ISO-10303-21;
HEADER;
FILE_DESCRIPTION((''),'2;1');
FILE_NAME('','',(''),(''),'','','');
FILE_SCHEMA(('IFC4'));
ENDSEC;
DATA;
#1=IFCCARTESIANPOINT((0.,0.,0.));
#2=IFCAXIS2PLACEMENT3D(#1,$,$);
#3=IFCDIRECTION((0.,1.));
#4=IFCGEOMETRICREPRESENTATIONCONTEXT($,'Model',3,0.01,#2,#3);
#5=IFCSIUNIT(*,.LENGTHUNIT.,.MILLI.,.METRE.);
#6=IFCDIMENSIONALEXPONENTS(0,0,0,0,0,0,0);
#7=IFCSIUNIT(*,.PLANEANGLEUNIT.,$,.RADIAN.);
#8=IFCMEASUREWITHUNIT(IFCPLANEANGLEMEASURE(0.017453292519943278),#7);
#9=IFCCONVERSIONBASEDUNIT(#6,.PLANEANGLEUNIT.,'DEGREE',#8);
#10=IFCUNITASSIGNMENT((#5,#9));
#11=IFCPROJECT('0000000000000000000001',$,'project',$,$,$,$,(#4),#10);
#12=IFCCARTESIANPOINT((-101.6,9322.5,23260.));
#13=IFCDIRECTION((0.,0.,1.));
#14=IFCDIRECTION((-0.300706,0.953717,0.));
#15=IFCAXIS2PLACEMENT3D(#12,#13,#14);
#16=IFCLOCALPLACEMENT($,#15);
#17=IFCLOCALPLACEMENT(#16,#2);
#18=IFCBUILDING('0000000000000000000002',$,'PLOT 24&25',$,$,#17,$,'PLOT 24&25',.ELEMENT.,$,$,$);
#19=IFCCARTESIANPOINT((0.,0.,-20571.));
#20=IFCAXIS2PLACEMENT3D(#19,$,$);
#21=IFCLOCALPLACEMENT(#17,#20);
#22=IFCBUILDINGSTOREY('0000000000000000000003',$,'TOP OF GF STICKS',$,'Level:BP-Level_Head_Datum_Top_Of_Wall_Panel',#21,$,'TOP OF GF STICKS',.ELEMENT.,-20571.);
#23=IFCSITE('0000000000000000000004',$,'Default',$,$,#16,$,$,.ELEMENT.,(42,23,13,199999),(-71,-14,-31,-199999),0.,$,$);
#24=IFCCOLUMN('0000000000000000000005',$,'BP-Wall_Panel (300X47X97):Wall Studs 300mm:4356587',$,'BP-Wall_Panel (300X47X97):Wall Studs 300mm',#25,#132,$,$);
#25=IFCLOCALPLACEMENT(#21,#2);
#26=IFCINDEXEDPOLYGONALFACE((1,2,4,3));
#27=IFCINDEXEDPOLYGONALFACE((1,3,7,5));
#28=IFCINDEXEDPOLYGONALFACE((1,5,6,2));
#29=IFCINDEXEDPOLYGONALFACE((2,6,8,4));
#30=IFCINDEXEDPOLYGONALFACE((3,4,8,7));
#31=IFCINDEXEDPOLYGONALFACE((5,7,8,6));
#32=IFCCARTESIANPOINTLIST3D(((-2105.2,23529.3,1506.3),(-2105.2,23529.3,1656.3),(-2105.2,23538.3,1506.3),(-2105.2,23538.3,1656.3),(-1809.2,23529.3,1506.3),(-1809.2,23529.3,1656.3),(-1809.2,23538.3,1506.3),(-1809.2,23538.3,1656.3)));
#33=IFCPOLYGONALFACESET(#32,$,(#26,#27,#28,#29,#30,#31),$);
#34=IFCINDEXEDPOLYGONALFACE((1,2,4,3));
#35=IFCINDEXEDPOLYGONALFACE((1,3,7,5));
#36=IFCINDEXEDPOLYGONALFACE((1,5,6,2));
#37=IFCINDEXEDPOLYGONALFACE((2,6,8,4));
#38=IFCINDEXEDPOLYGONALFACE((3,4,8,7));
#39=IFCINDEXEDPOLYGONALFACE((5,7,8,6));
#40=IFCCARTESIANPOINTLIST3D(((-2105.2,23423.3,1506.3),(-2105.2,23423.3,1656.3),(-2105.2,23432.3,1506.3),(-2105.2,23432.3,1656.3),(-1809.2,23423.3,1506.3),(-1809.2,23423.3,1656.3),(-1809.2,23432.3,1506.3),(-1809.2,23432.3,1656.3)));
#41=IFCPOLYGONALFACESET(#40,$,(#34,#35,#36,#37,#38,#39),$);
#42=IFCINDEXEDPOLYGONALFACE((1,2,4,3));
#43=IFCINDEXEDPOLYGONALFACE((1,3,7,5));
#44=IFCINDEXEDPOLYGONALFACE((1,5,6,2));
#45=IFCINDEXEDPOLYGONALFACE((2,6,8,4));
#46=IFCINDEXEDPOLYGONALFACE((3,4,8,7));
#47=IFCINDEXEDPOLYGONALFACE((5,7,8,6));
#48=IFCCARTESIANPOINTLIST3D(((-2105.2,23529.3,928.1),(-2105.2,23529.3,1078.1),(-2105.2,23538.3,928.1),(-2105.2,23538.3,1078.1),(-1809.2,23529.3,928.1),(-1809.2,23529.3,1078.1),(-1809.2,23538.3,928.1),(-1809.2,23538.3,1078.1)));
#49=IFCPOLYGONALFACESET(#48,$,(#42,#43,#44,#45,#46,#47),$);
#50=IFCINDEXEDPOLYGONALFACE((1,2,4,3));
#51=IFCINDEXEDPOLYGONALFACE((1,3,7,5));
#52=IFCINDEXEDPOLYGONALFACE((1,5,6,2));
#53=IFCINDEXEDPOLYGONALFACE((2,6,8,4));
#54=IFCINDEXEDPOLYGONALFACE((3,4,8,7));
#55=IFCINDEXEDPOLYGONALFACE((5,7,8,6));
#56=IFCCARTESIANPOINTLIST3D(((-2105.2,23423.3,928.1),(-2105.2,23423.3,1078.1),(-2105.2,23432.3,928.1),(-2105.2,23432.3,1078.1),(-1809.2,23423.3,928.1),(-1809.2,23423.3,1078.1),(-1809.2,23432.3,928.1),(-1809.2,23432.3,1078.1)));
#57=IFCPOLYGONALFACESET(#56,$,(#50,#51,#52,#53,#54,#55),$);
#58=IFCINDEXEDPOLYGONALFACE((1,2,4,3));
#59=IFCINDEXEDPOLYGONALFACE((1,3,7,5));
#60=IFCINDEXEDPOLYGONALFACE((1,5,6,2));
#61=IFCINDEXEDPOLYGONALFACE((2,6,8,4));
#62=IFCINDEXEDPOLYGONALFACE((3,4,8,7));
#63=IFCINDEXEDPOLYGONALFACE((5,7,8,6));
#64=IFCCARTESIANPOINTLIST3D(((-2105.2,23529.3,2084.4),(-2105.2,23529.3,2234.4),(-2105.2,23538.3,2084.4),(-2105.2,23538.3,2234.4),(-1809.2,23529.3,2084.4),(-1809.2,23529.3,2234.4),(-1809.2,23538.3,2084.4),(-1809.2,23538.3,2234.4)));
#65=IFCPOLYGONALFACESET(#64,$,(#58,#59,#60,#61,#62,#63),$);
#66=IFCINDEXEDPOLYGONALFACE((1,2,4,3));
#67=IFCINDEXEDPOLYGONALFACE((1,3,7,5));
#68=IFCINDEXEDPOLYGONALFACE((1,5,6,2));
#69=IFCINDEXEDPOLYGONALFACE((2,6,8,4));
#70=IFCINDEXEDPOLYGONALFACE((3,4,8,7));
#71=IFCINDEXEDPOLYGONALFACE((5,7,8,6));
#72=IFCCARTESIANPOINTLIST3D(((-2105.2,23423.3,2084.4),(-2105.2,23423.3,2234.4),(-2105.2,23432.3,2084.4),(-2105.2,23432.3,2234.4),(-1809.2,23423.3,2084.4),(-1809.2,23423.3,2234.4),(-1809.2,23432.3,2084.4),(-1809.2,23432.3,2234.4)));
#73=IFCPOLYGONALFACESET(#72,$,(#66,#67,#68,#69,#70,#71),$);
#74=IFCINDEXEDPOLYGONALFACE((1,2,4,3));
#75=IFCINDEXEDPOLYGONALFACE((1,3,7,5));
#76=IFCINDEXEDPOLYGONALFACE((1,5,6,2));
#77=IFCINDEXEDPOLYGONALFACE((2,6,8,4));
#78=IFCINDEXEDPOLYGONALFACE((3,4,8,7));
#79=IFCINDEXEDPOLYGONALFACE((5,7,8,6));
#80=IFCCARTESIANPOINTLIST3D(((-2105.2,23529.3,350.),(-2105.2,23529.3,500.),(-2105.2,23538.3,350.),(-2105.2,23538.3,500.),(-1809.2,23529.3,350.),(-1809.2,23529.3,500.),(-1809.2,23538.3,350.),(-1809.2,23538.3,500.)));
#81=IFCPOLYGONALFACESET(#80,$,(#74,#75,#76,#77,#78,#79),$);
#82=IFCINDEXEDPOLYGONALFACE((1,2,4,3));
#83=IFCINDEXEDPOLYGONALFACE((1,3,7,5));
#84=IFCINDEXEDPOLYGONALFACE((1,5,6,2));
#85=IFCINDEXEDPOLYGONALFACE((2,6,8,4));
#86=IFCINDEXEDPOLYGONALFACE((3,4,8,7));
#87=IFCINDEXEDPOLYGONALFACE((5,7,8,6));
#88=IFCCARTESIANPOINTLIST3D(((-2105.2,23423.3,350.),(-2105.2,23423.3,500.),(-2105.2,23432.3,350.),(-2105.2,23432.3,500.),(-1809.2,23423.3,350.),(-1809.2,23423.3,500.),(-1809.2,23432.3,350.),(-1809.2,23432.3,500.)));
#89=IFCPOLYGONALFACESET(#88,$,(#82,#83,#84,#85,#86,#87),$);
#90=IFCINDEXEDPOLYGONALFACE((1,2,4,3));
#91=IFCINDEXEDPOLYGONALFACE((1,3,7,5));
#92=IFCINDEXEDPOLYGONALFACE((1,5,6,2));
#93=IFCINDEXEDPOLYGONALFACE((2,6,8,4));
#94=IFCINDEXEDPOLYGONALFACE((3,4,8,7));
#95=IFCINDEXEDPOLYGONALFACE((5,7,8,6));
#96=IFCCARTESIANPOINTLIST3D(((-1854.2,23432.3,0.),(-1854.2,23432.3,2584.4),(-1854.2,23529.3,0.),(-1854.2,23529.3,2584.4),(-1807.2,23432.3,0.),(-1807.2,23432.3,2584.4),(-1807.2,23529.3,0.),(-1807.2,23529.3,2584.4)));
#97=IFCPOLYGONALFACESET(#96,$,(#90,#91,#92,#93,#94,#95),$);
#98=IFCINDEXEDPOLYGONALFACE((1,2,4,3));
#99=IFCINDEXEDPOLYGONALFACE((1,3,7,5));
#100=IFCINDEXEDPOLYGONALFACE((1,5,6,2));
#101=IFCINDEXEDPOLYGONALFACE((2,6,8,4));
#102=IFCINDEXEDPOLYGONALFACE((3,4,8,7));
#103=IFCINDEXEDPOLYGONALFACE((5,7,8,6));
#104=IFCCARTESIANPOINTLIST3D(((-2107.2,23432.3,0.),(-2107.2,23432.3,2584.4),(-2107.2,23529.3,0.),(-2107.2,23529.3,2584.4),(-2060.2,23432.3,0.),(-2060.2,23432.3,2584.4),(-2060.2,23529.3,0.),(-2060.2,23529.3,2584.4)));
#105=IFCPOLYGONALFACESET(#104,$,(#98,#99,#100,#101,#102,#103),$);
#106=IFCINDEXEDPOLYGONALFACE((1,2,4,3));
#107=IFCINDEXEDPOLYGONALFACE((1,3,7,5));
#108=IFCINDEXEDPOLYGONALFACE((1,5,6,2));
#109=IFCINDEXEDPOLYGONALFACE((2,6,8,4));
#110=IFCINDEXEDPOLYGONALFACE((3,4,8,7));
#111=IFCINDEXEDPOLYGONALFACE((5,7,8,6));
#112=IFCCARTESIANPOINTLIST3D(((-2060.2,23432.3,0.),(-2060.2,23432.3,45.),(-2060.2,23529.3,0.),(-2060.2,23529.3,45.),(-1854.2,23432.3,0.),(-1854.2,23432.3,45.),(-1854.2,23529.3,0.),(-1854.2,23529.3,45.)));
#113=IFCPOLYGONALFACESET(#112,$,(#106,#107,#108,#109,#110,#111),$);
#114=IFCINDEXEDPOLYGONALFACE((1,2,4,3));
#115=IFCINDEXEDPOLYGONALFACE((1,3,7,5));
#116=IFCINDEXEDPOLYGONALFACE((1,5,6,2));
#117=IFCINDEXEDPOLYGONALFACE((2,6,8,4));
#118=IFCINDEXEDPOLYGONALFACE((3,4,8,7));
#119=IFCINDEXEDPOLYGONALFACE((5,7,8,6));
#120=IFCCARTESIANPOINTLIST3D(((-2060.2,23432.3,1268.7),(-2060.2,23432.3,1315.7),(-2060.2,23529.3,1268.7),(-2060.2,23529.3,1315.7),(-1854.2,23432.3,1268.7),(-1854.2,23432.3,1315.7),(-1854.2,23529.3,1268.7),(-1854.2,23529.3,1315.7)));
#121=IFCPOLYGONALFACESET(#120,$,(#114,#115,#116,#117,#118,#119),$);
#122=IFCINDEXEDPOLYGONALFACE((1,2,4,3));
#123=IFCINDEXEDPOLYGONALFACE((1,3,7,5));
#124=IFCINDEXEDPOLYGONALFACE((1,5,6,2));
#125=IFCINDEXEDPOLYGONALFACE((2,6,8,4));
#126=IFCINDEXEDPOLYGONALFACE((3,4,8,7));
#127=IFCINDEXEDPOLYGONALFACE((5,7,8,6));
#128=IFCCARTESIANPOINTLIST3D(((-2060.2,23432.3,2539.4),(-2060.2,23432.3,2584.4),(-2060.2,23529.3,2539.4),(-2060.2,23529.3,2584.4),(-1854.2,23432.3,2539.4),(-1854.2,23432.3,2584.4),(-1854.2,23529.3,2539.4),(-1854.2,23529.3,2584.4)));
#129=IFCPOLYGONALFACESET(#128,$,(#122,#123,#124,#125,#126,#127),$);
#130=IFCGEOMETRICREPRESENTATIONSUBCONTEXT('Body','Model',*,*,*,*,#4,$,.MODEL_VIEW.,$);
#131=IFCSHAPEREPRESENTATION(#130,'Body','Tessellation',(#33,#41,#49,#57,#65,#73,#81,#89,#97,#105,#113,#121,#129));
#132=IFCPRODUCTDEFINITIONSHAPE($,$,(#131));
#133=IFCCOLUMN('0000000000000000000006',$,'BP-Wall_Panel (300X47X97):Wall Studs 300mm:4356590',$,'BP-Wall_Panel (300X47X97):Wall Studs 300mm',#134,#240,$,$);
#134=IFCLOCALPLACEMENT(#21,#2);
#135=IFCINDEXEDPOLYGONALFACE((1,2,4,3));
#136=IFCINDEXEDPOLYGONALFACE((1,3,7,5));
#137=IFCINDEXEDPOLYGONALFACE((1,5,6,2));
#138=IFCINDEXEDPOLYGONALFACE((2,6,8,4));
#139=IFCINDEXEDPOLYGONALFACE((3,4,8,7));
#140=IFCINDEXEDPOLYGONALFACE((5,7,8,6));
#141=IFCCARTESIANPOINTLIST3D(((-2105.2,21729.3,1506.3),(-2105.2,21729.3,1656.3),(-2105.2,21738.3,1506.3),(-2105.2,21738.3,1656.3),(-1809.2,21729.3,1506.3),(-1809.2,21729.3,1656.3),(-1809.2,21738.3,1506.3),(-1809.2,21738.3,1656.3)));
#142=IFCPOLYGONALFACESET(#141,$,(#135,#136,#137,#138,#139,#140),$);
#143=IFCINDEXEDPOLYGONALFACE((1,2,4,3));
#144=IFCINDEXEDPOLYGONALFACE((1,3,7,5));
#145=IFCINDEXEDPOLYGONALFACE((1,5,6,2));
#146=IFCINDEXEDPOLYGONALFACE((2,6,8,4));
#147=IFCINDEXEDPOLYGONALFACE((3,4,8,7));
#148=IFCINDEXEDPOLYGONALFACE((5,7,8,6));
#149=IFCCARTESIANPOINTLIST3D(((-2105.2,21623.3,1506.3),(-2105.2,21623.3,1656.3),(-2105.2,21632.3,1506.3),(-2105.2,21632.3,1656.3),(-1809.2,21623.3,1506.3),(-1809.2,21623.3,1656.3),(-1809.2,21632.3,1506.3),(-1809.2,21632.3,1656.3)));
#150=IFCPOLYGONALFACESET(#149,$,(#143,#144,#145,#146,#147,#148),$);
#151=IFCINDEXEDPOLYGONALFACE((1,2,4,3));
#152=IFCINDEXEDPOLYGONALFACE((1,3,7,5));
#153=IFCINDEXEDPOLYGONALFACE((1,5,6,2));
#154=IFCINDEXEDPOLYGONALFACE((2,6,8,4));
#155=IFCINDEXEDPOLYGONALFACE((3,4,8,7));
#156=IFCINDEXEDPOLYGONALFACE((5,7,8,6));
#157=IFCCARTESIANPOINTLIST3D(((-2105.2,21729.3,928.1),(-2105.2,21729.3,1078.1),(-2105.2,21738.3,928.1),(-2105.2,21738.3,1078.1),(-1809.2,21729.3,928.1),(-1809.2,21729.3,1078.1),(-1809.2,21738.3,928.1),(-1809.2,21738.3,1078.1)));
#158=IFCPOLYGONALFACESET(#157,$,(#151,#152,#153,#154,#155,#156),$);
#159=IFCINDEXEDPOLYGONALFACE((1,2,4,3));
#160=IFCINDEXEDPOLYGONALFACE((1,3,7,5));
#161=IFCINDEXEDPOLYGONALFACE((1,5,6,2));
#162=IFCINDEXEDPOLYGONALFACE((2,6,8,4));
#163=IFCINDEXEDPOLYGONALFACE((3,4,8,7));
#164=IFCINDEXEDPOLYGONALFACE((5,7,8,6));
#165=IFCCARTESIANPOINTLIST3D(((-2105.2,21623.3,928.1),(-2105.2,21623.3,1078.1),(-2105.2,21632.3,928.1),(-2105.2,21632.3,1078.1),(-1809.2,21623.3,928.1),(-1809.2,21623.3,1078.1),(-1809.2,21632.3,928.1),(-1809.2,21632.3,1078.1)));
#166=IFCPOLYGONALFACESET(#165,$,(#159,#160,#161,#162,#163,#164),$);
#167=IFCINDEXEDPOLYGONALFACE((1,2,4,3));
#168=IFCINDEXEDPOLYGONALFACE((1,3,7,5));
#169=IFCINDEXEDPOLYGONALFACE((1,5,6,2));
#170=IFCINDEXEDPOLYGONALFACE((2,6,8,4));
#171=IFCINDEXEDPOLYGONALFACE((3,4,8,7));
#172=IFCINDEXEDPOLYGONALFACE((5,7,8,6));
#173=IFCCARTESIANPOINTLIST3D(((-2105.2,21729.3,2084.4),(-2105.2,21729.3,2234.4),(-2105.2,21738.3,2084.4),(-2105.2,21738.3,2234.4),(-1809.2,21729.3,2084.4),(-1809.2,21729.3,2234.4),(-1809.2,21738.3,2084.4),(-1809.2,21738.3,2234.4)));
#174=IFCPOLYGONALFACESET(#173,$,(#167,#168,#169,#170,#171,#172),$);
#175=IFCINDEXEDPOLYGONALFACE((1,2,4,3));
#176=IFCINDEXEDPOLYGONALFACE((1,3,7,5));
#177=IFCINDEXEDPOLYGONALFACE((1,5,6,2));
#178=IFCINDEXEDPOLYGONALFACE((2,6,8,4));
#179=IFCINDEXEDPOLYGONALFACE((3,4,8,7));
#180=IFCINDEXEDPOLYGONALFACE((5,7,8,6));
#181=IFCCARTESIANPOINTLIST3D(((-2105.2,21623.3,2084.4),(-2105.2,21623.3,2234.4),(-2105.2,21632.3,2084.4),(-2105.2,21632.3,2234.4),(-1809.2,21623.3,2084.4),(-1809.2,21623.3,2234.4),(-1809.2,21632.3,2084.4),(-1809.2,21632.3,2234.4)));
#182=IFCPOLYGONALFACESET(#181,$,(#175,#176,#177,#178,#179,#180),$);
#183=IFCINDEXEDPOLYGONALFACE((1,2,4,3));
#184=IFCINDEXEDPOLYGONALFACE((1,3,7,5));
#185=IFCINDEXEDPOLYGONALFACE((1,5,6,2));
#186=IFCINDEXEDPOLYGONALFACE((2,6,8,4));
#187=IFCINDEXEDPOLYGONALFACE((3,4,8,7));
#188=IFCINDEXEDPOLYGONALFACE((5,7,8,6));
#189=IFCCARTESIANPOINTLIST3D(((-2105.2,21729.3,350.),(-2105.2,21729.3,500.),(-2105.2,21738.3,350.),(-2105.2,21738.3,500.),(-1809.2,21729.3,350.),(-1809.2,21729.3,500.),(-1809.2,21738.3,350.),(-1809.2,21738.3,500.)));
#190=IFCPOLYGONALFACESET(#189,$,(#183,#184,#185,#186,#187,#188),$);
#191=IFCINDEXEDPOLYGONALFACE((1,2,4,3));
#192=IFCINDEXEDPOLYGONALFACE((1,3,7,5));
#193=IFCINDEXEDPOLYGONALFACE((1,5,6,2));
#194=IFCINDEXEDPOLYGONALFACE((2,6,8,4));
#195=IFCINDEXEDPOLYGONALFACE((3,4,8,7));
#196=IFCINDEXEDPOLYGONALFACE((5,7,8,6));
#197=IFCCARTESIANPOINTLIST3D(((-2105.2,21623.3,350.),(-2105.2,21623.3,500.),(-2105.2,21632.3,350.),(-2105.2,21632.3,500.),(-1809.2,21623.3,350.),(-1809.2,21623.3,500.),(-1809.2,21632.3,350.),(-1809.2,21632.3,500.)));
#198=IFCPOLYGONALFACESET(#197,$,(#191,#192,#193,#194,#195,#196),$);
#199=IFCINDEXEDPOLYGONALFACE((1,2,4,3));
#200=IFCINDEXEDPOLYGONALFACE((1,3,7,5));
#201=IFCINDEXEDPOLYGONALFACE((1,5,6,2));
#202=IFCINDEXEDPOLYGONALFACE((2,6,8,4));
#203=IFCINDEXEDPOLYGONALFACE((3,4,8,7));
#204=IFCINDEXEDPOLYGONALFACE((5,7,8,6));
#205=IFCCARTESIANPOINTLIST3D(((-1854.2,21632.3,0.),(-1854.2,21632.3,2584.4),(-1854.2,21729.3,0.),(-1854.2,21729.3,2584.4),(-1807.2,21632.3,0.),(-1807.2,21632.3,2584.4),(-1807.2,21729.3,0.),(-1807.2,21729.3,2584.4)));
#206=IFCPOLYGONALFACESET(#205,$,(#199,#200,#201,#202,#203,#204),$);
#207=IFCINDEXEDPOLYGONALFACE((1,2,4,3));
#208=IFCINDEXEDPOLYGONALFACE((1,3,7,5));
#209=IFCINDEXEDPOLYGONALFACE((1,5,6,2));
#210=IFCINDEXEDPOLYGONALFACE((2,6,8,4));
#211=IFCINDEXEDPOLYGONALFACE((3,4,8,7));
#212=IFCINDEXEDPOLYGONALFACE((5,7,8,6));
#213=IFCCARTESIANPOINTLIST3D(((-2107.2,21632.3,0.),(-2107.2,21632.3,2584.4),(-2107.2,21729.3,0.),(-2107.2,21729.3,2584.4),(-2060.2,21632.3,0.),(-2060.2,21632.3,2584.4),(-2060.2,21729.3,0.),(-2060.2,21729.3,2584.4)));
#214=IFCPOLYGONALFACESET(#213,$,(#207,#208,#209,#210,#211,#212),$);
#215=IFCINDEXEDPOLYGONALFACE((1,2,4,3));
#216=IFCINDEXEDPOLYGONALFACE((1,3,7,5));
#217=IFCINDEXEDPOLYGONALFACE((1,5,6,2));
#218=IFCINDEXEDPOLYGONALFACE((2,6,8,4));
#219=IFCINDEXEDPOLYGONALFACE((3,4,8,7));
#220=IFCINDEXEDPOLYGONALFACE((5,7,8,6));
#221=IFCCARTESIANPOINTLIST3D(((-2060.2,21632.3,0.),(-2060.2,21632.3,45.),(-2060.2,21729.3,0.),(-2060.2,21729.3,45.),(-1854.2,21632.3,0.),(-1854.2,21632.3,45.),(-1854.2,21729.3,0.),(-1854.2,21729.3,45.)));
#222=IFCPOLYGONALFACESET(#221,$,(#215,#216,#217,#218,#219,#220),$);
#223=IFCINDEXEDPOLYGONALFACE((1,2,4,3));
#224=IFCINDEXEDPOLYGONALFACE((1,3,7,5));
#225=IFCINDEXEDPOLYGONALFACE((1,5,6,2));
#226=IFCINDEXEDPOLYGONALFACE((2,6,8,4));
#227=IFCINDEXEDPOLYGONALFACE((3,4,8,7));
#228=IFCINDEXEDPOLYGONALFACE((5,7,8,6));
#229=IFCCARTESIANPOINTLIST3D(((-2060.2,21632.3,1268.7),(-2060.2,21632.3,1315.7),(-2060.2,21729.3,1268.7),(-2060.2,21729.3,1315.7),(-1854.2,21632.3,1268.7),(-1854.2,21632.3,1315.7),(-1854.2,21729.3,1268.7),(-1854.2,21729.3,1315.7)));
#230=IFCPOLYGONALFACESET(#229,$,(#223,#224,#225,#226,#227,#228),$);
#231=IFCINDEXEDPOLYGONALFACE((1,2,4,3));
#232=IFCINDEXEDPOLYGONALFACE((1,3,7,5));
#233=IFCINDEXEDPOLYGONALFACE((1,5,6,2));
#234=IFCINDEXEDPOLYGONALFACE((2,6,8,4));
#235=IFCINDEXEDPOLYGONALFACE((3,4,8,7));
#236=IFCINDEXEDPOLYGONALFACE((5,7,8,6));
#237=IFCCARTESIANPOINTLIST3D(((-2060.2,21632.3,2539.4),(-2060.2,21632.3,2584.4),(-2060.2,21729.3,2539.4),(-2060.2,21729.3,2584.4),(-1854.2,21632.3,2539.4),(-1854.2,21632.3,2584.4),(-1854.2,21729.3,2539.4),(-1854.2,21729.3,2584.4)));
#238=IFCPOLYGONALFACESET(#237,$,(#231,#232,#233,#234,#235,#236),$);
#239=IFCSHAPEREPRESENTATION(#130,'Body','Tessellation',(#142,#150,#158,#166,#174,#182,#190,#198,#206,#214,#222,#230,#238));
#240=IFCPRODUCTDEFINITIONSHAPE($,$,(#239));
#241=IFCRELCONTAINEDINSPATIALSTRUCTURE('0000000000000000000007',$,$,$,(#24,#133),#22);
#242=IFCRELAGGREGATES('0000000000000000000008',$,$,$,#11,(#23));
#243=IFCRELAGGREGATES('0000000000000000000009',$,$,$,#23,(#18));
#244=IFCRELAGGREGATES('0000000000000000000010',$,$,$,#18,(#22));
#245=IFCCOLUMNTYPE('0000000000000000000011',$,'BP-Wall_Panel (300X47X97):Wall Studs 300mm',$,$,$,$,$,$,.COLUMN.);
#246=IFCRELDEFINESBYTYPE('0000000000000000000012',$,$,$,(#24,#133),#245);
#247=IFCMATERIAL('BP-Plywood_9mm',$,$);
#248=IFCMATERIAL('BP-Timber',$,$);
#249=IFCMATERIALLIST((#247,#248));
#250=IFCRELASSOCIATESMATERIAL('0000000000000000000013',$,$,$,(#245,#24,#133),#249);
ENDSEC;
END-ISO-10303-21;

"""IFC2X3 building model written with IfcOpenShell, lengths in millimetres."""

from ifc_helpers import new_model, entity, si_unit, converted_unit, direction, frame, frame_2d, origin, origin_2d_with_axis, place, context, subcontext, project, spatial, rectangle, extrude, source, transform, mapped, material, material_list, type_object, type_shapes, element, save


model = new_model("IFC2X3")

# Units and contexts
model_context = context("Model", 3, precision=0.01, world=origin(), true_north=direction((0.0, 1.0)))
body_context = subcontext(model_context, "Body", "Model", "MODEL_VIEW")
ifc_project = project(units=[si_unit("LENGTHUNIT", "METRE", prefix="MILLI"), converted_unit("PLANEANGLEUNIT", "DEGREE", entity("IfcPlaneAngleMeasure", 0.017453292519943278), si_unit("PLANEANGLEUNIT", "RADIAN"), dimensions=[0, 0, 0, 0, 0, 0, 0])], contexts=[model_context])

# Site, building, storey
site_placement = place(None, frame((-101.6, 9322.5, 23260.0), z_axis=(0.0, 0.0, 1.0), x_axis=(-0.300706, 0.953717, 0.0)))
site = spatial("IfcSite", under=ifc_project, at=site_placement, Name="Default", CompositionType="ELEMENT", RefLatitude=(42, 23, 13, 199999), RefLongitude=(-71, -14, -31, -199999), RefElevation=0.0)
building_placement = place(site_placement, origin())
building = spatial("IfcBuilding", under=site, at=building_placement, Name="PLOT 24&25", LongName="PLOT 24&25", CompositionType="ELEMENT")
storey_placement = place(building_placement, frame((0.0, 0.0, -20571.0)))
storey = spatial("IfcBuildingStorey", under=building, at=storey_placement, Name="TOP OF GF STICKS", ObjectType="Level:BP-Level_Head_Datum_Top_Of_Wall_Panel", LongName="TOP OF GF STICKS", CompositionType="ELEMENT", Elevation=-20571.0)

# Columns
ifc_material_1 = material(Name="BP-Plywood_9mm")
ifc_material_2 = material(Name="BP-Timber")
ifc_material_list = material_list([ifc_material_1, ifc_material_2])
column_type_1 = type_object("IfcColumnType", Name="BP-Wall_Panel (300X47X97):Wall Studs 300mm", PredefinedType="COLUMN", material=ifc_material_list)
shared_shape_1 = source(origin(), body_context, "Body", "SweptSolid", [
    extrude(rectangle(XDim=296.0, YDim=9.0, at=origin_2d_with_axis()), frame((53.0, 0.0, -19064.7), z_axis=(0.0, 0.0, 1.0), x_axis=(0.0, -1.0, 0.0)), (0.0, 0.0, 1.0), 150.0),
    extrude(rectangle(XDim=9.0, YDim=296.0, at=origin_2d_with_axis()), frame((-53.0, 0.0, -19064.7), z_axis=(0.0, 0.0, 1.0), x_axis=(-1.0, 0.0, 0.0)), (0.0, 0.0, 1.0), 150.0),
    extrude(rectangle(XDim=296.0, YDim=9.0, at=origin_2d_with_axis()), frame((53.0, 0.0, -19642.9), z_axis=(0.0, 0.0, 1.0), x_axis=(0.0, -1.0, 0.0)), (0.0, 0.0, 1.0), 150.0),
    extrude(rectangle(XDim=9.0, YDim=296.0, at=origin_2d_with_axis()), frame((-53.0, 0.0, -19642.9), z_axis=(0.0, 0.0, 1.0), x_axis=(-1.0, 0.0, 0.0)), (0.0, 0.0, 1.0), 150.0),
    extrude(rectangle(XDim=296.0, YDim=9.0, at=origin_2d_with_axis()), frame((53.0, 0.0, -18486.6), z_axis=(0.0, 0.0, 1.0), x_axis=(0.0, -1.0, 0.0)), (0.0, 0.0, 1.0), 150.0),
    extrude(rectangle(XDim=9.0, YDim=296.0, at=origin_2d_with_axis()), frame((-53.0, 0.0, -18486.6), z_axis=(0.0, 0.0, 1.0), x_axis=(-1.0, 0.0, 0.0)), (0.0, 0.0, 1.0), 150.0),
    extrude(rectangle(XDim=296.0, YDim=9.0, at=origin_2d_with_axis()), frame((53.0, 0.0, -20221.0), z_axis=(0.0, 0.0, 1.0), x_axis=(0.0, -1.0, 0.0)), (0.0, 0.0, 1.0), 150.0),
    extrude(rectangle(XDim=9.0, YDim=296.0, at=origin_2d_with_axis()), frame((-53.0, 0.0, -20221.0), z_axis=(0.0, 0.0, 1.0), x_axis=(-1.0, 0.0, 0.0)), (0.0, 0.0, 1.0), 150.0),
    extrude(rectangle(XDim=97.0, YDim=47.0, at=origin_2d_with_axis()), frame((0.0, -126.5, -20571.0), z_axis=(0.0, 0.0, 1.0), x_axis=(-1.0, 0.0, 0.0)), (0.0, 0.0, 1.0), 2584.4),
    extrude(rectangle(XDim=97.0, YDim=47.0, at=frame_2d((0.0, 0.0), x_axis=(1.0, 0.0))), frame((0.0, 126.5, -20571.0), z_axis=(0.0, 0.0, 1.0), x_axis=(-1.0, 0.0, 0.0)), (0.0, 0.0, 1.0), 2584.4),
    extrude(rectangle(XDim=206.0, YDim=97.0, at=origin_2d_with_axis()), frame((0.0, 0.0, -20571.0), z_axis=(0.0, 0.0, 1.0), x_axis=(0.0, -1.0, 0.0)), (0.0, 0.0, 1.0), 45.0),
    extrude(rectangle(XDim=206.0, YDim=97.0, at=origin_2d_with_axis()), frame((0.0, 0.0, -19302.3), z_axis=(0.0, 0.0, 1.0), x_axis=(0.0, -1.0, 0.0)), (0.0, 0.0, 1.0), 47.0),
    extrude(rectangle(XDim=206.0, YDim=97.0, at=origin_2d_with_axis()), frame((0.0, 0.0, -18031.6), z_axis=(0.0, 0.0, 1.0), x_axis=(0.0, -1.0, 0.0)), (0.0, 0.0, 1.0), 45.0),
])
type_shapes(column_type_1, [shared_shape_1])
for number, where, z_axis, x_axis, name in (
    (1, (-1957.2, 23480.8, 20571.0), (0.0, 0.0, 1.0), (0.0, 1.0, 0.0), "BP-Wall_Panel (300X47X97):Wall Studs 300mm:4356587"),
    (2, (-1957.2, 21680.8, 20571.0), (0.0, 0.0, 1.0), (0.0, 1.0, 0.0), "BP-Wall_Panel (300X47X97):Wall Studs 300mm:4356590"),
):
    element("IfcColumn", number, at=place(storey_placement, frame(where, z_axis=z_axis, x_axis=x_axis)), inside=storey, type_object=column_type_1, material=ifc_material_list, Name=name, ObjectType="BP-Wall_Panel (300X47X97):Wall Studs 300mm", context=body_context, shape_type="MappedRepresentation", body=[
        mapped(shared_shape_1, transform((0.0, 0.0, 0.0), scale=1.0)),
    ])

save(model, "model.ifc")
